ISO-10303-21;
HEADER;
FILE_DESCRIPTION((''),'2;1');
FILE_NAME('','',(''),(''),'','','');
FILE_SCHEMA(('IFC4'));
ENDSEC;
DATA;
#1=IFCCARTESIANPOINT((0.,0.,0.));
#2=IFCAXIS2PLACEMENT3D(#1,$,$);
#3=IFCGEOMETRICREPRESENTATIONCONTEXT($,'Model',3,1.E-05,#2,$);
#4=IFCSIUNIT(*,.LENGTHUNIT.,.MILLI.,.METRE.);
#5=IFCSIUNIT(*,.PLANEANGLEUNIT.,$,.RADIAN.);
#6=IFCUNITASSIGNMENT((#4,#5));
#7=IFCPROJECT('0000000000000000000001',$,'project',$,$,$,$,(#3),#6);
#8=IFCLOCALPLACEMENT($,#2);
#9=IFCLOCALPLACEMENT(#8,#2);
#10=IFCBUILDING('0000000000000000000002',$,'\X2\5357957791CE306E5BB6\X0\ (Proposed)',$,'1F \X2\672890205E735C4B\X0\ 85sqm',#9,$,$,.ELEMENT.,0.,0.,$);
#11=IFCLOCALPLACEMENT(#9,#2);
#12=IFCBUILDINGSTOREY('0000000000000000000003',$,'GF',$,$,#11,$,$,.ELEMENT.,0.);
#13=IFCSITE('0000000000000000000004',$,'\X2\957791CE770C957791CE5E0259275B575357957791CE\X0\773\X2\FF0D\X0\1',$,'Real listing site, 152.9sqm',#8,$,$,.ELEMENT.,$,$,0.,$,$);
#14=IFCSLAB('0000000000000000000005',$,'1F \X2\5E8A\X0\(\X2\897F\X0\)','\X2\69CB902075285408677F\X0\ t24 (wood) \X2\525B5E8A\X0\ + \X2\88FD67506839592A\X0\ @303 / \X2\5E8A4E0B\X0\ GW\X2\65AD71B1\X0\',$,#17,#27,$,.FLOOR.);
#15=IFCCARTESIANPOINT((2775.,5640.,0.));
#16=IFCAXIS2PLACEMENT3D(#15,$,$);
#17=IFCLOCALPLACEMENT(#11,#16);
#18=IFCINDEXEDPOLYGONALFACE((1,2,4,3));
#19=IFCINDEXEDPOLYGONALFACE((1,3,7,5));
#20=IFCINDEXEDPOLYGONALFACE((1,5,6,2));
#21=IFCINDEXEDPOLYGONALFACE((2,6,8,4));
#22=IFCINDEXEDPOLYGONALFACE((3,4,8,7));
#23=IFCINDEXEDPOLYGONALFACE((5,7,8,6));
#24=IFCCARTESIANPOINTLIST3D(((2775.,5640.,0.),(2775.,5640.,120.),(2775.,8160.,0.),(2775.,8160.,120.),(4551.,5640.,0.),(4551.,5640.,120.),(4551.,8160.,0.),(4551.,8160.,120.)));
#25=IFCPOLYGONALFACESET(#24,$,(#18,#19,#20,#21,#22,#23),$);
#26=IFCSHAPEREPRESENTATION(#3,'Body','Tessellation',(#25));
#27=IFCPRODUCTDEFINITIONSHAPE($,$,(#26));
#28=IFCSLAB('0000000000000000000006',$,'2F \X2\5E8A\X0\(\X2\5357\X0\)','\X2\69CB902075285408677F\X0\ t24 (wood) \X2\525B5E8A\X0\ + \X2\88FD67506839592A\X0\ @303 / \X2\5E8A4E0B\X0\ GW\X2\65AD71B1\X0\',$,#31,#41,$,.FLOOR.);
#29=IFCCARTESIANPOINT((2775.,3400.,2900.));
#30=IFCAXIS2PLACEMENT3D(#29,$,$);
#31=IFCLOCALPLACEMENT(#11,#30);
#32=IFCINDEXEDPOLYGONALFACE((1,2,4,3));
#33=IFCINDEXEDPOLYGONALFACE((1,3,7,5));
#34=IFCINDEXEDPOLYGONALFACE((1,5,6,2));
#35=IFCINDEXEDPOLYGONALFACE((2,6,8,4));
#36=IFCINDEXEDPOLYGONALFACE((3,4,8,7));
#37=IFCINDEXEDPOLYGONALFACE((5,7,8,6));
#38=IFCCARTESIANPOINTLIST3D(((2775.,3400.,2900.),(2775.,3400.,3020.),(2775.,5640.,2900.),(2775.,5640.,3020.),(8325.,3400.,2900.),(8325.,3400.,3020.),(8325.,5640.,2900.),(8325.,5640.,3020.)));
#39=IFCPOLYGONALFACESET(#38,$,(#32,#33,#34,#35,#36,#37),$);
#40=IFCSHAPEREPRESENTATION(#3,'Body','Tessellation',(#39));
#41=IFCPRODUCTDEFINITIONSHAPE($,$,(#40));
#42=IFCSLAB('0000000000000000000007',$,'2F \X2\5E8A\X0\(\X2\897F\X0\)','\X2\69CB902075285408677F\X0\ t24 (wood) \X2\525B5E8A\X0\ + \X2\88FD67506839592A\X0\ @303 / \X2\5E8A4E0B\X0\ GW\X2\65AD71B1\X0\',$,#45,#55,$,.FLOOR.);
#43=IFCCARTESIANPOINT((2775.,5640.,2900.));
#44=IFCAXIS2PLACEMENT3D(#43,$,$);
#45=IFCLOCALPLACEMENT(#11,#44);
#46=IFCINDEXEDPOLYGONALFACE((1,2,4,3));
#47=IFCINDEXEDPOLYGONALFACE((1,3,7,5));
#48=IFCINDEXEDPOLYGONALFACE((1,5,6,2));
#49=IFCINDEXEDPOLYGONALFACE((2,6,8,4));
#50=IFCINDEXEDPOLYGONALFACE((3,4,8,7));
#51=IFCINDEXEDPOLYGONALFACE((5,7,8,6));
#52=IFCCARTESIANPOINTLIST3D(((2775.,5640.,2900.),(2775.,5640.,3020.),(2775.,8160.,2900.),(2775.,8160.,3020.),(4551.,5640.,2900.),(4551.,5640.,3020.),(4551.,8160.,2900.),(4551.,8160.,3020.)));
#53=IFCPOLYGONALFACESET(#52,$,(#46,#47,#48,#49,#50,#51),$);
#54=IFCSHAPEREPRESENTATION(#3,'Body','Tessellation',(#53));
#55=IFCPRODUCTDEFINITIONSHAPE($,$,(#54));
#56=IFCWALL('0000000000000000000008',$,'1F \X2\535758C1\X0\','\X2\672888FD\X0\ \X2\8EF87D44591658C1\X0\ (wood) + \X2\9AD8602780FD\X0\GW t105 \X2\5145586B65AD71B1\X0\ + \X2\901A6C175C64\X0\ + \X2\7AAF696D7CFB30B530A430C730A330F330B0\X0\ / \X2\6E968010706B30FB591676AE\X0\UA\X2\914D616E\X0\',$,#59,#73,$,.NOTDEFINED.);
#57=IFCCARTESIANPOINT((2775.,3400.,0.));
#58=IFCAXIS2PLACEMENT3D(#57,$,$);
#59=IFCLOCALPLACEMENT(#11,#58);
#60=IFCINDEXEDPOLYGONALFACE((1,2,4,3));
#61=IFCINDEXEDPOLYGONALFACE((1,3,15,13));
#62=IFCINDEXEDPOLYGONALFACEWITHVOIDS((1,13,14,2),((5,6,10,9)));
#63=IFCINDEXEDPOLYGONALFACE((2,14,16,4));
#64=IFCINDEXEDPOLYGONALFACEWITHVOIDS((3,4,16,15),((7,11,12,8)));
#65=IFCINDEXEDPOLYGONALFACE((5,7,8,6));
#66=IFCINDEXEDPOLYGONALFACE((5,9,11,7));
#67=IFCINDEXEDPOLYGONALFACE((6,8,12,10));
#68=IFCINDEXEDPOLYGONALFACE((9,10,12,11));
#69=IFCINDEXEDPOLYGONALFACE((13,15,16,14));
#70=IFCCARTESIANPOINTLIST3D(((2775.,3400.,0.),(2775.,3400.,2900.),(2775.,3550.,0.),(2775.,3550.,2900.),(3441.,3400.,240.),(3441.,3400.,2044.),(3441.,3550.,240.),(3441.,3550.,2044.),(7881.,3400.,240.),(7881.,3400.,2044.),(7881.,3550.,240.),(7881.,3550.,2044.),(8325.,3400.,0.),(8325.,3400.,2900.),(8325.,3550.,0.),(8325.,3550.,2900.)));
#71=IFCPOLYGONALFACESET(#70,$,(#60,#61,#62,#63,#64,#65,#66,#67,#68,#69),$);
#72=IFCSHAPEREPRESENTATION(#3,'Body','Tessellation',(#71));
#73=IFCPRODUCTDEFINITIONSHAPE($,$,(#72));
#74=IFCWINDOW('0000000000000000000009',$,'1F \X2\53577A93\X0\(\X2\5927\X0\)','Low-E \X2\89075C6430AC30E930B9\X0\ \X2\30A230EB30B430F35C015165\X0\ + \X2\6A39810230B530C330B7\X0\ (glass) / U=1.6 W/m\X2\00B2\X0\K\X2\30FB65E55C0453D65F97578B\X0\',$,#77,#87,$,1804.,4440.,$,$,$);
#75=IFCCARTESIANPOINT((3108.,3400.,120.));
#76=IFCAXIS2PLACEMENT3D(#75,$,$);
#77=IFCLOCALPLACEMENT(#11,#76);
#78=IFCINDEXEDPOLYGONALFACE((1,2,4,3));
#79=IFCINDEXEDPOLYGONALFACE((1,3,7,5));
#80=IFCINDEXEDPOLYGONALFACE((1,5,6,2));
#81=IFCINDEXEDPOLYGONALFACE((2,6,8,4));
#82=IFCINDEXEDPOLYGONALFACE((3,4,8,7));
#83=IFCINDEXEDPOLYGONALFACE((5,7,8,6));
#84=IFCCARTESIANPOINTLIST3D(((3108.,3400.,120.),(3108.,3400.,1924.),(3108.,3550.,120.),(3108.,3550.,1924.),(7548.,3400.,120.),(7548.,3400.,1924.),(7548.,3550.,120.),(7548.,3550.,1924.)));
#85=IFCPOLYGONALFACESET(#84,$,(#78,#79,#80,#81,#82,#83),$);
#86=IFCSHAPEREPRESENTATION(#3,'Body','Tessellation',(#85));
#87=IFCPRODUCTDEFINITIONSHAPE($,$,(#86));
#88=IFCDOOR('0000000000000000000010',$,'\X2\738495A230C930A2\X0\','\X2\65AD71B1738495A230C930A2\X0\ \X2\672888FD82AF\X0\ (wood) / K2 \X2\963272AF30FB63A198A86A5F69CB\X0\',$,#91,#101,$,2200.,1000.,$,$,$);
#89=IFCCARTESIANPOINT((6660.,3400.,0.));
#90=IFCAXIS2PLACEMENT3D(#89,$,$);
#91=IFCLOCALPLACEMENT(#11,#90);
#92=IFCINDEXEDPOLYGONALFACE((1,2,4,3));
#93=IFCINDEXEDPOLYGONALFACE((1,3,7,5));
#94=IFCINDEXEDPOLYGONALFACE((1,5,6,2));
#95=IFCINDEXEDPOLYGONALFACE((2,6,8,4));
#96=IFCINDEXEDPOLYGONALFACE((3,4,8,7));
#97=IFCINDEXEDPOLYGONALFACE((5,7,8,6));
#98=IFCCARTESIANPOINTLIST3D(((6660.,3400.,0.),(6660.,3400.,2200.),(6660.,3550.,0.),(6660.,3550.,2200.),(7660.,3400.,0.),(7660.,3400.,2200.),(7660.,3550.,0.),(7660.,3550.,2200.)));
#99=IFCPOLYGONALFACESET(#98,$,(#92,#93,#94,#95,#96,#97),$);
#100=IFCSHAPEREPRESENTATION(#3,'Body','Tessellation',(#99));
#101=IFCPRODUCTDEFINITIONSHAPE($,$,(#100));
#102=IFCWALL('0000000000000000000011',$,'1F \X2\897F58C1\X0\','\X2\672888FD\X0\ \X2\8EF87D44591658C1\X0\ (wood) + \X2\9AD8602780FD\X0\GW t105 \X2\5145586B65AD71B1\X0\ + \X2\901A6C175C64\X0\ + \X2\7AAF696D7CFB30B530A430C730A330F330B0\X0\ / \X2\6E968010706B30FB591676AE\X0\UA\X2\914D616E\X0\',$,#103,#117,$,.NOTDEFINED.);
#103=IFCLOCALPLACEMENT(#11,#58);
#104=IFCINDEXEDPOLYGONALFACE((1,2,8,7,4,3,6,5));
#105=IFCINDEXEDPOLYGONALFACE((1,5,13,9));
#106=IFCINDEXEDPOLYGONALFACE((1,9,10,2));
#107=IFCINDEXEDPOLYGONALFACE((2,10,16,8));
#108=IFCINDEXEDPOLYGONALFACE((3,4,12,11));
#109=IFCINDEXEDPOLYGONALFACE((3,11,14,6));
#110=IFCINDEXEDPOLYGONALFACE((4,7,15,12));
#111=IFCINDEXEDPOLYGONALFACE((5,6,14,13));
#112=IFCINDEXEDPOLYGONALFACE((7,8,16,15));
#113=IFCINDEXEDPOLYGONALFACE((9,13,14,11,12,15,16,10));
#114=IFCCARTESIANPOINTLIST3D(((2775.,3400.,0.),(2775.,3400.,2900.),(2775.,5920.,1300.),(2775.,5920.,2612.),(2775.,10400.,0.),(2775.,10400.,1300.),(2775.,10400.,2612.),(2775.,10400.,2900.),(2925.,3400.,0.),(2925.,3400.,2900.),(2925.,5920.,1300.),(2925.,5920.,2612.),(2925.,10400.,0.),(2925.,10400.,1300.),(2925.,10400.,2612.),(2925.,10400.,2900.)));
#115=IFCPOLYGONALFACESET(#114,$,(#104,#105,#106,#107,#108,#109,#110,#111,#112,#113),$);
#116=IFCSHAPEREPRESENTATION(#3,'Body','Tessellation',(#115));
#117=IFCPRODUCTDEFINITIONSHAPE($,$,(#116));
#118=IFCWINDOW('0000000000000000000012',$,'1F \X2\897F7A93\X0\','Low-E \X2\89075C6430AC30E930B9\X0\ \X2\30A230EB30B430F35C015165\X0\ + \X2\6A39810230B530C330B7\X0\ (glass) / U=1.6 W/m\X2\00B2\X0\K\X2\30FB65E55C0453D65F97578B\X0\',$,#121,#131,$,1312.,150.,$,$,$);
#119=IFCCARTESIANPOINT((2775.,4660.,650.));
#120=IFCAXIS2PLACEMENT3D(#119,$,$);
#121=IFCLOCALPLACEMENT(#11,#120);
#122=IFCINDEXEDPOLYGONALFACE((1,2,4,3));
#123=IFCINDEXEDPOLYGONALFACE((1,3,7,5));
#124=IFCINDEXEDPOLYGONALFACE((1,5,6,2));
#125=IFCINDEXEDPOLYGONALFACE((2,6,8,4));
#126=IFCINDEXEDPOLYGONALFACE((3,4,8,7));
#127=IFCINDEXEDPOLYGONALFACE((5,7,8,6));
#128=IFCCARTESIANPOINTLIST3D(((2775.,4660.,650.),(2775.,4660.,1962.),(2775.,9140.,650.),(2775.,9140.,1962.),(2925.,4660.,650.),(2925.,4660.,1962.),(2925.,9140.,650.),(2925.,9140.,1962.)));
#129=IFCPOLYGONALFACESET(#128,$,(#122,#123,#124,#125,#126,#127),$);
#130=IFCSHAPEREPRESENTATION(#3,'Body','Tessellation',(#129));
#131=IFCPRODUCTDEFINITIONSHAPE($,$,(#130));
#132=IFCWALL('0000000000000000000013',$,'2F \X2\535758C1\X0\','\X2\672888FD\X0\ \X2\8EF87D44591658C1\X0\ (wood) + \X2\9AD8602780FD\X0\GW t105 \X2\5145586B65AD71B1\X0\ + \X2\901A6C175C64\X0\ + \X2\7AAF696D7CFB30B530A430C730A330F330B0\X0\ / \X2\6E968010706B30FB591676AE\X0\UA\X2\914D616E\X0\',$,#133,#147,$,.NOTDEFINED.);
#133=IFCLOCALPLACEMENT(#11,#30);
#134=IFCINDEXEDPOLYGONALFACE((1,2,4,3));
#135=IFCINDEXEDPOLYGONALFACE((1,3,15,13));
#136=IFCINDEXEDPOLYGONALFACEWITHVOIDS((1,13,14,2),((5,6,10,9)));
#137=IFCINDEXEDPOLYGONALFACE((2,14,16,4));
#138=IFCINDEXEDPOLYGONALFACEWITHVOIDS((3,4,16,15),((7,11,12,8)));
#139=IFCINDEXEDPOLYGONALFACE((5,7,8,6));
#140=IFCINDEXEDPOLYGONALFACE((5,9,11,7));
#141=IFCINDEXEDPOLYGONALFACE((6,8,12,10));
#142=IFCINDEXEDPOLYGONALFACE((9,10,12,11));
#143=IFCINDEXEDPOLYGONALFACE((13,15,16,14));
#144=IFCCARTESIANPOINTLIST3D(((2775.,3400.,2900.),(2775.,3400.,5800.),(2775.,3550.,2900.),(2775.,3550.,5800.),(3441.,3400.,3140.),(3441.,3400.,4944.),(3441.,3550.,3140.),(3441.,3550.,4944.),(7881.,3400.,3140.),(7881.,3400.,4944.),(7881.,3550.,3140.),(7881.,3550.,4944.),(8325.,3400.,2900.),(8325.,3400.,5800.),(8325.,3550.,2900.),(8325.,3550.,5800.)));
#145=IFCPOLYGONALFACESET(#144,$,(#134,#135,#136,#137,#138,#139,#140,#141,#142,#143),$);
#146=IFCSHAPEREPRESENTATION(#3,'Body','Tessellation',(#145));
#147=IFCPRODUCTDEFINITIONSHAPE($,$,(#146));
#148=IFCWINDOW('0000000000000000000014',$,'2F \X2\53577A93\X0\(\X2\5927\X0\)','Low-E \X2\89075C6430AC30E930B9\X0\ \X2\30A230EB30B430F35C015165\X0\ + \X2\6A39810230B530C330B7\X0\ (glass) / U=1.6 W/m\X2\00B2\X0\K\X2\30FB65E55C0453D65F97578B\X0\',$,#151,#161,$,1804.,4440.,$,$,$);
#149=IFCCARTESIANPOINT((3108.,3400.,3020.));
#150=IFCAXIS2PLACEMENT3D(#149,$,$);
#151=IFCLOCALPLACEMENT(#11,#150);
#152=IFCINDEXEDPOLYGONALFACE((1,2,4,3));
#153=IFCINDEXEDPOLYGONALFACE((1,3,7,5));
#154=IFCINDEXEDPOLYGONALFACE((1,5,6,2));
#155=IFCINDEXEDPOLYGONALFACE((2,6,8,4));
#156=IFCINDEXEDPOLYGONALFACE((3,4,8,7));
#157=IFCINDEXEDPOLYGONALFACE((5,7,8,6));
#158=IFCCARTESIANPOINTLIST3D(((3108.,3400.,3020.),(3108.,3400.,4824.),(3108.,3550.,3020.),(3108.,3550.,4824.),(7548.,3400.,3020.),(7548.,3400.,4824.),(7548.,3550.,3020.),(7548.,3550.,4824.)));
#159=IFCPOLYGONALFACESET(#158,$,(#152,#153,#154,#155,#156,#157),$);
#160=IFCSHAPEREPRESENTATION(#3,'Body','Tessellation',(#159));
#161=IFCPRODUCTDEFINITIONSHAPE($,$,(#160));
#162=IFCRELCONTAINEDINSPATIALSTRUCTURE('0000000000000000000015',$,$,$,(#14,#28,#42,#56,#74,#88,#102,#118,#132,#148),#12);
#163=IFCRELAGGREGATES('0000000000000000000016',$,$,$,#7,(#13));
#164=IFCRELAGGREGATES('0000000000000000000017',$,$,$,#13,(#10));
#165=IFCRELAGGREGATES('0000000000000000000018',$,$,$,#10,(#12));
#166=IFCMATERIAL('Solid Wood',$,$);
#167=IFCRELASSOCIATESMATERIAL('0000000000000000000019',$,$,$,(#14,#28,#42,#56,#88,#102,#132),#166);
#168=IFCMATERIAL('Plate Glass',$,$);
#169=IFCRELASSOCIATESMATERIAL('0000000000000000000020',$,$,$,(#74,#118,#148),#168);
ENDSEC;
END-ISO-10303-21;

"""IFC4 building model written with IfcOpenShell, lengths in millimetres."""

from ifc_helpers import new_model, si_unit, frame, frame_2d, origin, place, context, project, spatial, rectangle, extrude, material, element, fill, save


model = new_model("IFC4")

# Units and contexts
model_context = context("Model", 3, precision=1e-05, world=origin())
ifc_project = project(units=[si_unit("LENGTHUNIT", "METRE", prefix="MILLI"), si_unit("PLANEANGLEUNIT", "RADIAN")], contexts=[model_context])

# Site, building, storey
site_placement = place(None, origin())
site = spatial("IfcSite", under=ifc_project, at=site_placement, Name="長野県長野市大字南長野773－1", ObjectType="Real listing site, 152.9sqm", CompositionType="ELEMENT", RefElevation=0.0)
building_placement = place(site_placement, origin())
building = spatial("IfcBuilding", under=site, at=building_placement, Name="南長野の家 (Proposed)", ObjectType="1F 木造平屋 85sqm", CompositionType="ELEMENT", ElevationOfRefHeight=0.0, ElevationOfTerrain=0.0)
storey_placement = place(building_placement, origin())
storey = spatial("IfcBuildingStorey", under=building, at=storey_placement, Name="GF", CompositionType="ELEMENT", Elevation=0.0)

# Slabs
ifc_material_1 = material(Name="Solid Wood")
slab_1_placement = place(storey_placement, frame((2775.0, 5640.0, 0.0)))
element("IfcSlab", 1, at=slab_1_placement, inside=storey, material=ifc_material_1, Name="1F 床(西)", Description="構造用合板 t24 (wood) 剛床 + 製材根太 @303 / 床下 GW断熱", PredefinedType="FLOOR", context=model_context, shape_type="SweptSolid", body=[
    extrude(rectangle(XDim=1776.0, YDim=2520.0, at=frame_2d((888.0, 1260.0))), frame((2775.0, 5640.0, 0.0)), (0.0, 0.0, 1.0), 120.0),
])
slab_2_placement = place(storey_placement, frame((2775.0, 3400.0, 2900.0)))
element("IfcSlab", 2, at=slab_2_placement, inside=storey, material=ifc_material_1, Name="2F 床(南)", Description="構造用合板 t24 (wood) 剛床 + 製材根太 @303 / 床下 GW断熱", PredefinedType="FLOOR", context=model_context, shape_type="SweptSolid", body=[
    extrude(rectangle(XDim=5550.0, YDim=2240.0, at=frame_2d((2775.0, 1120.0))), frame((2775.0, 3400.0, 2900.0)), (0.0, 0.0, 1.0), 120.0),
])
slab_3_placement = place(storey_placement, frame((2775.0, 5640.0, 2900.0)))
element("IfcSlab", 3, at=slab_3_placement, inside=storey, material=ifc_material_1, Name="2F 床(西)", Description="構造用合板 t24 (wood) 剛床 + 製材根太 @303 / 床下 GW断熱", PredefinedType="FLOOR", context=model_context, shape_type="SweptSolid", body=[
    extrude(rectangle(XDim=1776.0, YDim=2520.0, at=frame_2d((888.0, 1260.0))), frame((2775.0, 5640.0, 2900.0)), (0.0, 0.0, 1.0), 120.0),
])

# Wall, openings, window, door
wall_1_placement = place(storey_placement, frame((2775.0, 3400.0, 0.0)))
wall_1 = element("IfcWall", 4, at=wall_1_placement, inside=storey, material=ifc_material_1, Name="1F 南壁", Description="木製 軸組外壁 (wood) + 高性能GW t105 充填断熱 + 通気層 + 窯業系サイディング / 準耐火・外皮UA配慮", PredefinedType="NOTDEFINED", context=model_context, shape_type="SweptSolid", body=[
    extrude(rectangle(XDim=5550.0, YDim=150.0, at=frame_2d((2775.0, 75.0))), frame((2775.0, 3400.0, 0.0)), (0.0, 0.0, 1.0), 2900.0),
])
opening_1_placement = place(storey_placement, frame((3108.0, 3400.0, 120.0)))
opening_1 = element("IfcOpeningElement", 5, at=opening_1_placement, cuts=wall_1, PredefinedType="NOTDEFINED", context=model_context, shape_type="SweptSolid", body=[
    extrude(rectangle(XDim=4440.0, YDim=150.0, at=frame_2d((2220.0, 75.0))), frame((3108.0, 3400.0, 120.0)), (0.0, 0.0, 1.0), 1804.0),
])
opening_2_placement = place(storey_placement, frame((6660.0, 3400.0, 0.0)))
opening_2 = element("IfcOpeningElement", 6, at=opening_2_placement, cuts=wall_1, PredefinedType="NOTDEFINED", context=model_context, shape_type="SweptSolid", body=[
    extrude(rectangle(XDim=1000.0, YDim=150.0, at=frame_2d((500.0, 75.0))), frame((6660.0, 3400.0, 0.0)), (0.0, 0.0, 1.0), 2200.0),
])
ifc_material_2 = material(Name="Plate Glass")
window_1_placement = place(storey_placement, frame((3108.0, 3400.0, 120.0)))
window_1 = element("IfcWindow", 7, at=window_1_placement, inside=storey, material=ifc_material_2, Name="1F 南窓(大)", Description="Low-E 複層ガラス アルゴン封入 + 樹脂サッシ (glass) / U=1.6 W/m²K・日射取得型", OverallHeight=1804.0, OverallWidth=4440.0, context=model_context, shape_type="SweptSolid", body=[
    extrude(rectangle(XDim=4440.0, YDim=150.0, at=frame_2d((2220.0, 75.0))), frame((3108.0, 3400.0, 120.0)), (0.0, 0.0, 1.0), 1804.0),
])
fill(opening_1, window_1)
door_placement = place(storey_placement, frame((6660.0, 3400.0, 0.0)))
door = element("IfcDoor", 8, at=door_placement, inside=storey, material=ifc_material_1, Name="玄関ドア", Description="断熱玄関ドア 木製芯 (wood) / K2 防犯・採風機構", OverallHeight=2200.0, OverallWidth=1000.0, context=model_context, shape_type="SweptSolid", body=[
    extrude(rectangle(XDim=1000.0, YDim=150.0, at=frame_2d((500.0, 75.0))), frame((6660.0, 3400.0, 0.0)), (0.0, 0.0, 1.0), 2200.0),
])
fill(opening_2, door)

# Walls, openings, windows
wall_2_placement = place(storey_placement, frame((2775.0, 3400.0, 0.0)))
wall_2 = element("IfcWall", 9, at=wall_2_placement, inside=storey, material=ifc_material_1, Name="1F 西壁", Description="木製 軸組外壁 (wood) + 高性能GW t105 充填断熱 + 通気層 + 窯業系サイディング / 準耐火・外皮UA配慮", PredefinedType="NOTDEFINED", context=model_context, shape_type="SweptSolid", body=[
    extrude(rectangle(XDim=150.0, YDim=7000.0, at=frame_2d((75.0, 3500.0))), frame((2775.0, 3400.0, 0.0)), (0.0, 0.0, 1.0), 2900.0),
])
opening_3_placement = place(storey_placement, frame((2775.0, 4660.0, 650.0)))
opening_3 = element("IfcOpeningElement", 10, at=opening_3_placement, cuts=wall_2, PredefinedType="NOTDEFINED", context=model_context, shape_type="SweptSolid", body=[
    extrude(rectangle(XDim=150.0, YDim=4480.0, at=frame_2d((75.0, 2240.0))), frame((2775.0, 4660.0, 650.0)), (0.0, 0.0, 1.0), 1312.0),
])
window_2_placement = place(storey_placement, frame((2775.0, 4660.0, 650.0)))
window_2 = element("IfcWindow", 11, at=window_2_placement, inside=storey, material=ifc_material_2, Name="1F 西窓", Description="Low-E 複層ガラス アルゴン封入 + 樹脂サッシ (glass) / U=1.6 W/m²K・日射取得型", OverallHeight=1312.0, OverallWidth=150.0, context=model_context, shape_type="SweptSolid", body=[
    extrude(rectangle(XDim=150.0, YDim=4480.0, at=frame_2d((75.0, 2240.0))), frame((2775.0, 4660.0, 650.0)), (0.0, 0.0, 1.0), 1312.0),
])
fill(opening_3, window_2)
wall_3_placement = place(storey_placement, frame((2775.0, 3400.0, 2900.0)))
wall_3 = element("IfcWall", 12, at=wall_3_placement, inside=storey, material=ifc_material_1, Name="2F 南壁", Description="木製 軸組外壁 (wood) + 高性能GW t105 充填断熱 + 通気層 + 窯業系サイディング / 準耐火・外皮UA配慮", PredefinedType="NOTDEFINED", context=model_context, shape_type="SweptSolid", body=[
    extrude(rectangle(XDim=5550.0, YDim=150.0, at=frame_2d((2775.0, 75.0))), frame((2775.0, 3400.0, 2900.0)), (0.0, 0.0, 1.0), 2900.0),
])
opening_4_placement = place(storey_placement, frame((3108.0, 3400.0, 3020.0)))
opening_4 = element("IfcOpeningElement", 13, at=opening_4_placement, cuts=wall_3, PredefinedType="NOTDEFINED", context=model_context, shape_type="SweptSolid", body=[
    extrude(rectangle(XDim=4440.0, YDim=150.0, at=frame_2d((2220.0, 75.0))), frame((3108.0, 3400.0, 3020.0)), (0.0, 0.0, 1.0), 1804.0),
])
window_3_placement = place(storey_placement, frame((3108.0, 3400.0, 3020.0)))
window_3 = element("IfcWindow", 14, at=window_3_placement, inside=storey, material=ifc_material_2, Name="2F 南窓(大)", Description="Low-E 複層ガラス アルゴン封入 + 樹脂サッシ (glass) / U=1.6 W/m²K・日射取得型", OverallHeight=1804.0, OverallWidth=4440.0, context=model_context, shape_type="SweptSolid", body=[
    extrude(rectangle(XDim=4440.0, YDim=150.0, at=frame_2d((2220.0, 75.0))), frame((3108.0, 3400.0, 3020.0)), (0.0, 0.0, 1.0), 1804.0),
])
fill(opening_4, window_3)

save(model, "model.ifc")
